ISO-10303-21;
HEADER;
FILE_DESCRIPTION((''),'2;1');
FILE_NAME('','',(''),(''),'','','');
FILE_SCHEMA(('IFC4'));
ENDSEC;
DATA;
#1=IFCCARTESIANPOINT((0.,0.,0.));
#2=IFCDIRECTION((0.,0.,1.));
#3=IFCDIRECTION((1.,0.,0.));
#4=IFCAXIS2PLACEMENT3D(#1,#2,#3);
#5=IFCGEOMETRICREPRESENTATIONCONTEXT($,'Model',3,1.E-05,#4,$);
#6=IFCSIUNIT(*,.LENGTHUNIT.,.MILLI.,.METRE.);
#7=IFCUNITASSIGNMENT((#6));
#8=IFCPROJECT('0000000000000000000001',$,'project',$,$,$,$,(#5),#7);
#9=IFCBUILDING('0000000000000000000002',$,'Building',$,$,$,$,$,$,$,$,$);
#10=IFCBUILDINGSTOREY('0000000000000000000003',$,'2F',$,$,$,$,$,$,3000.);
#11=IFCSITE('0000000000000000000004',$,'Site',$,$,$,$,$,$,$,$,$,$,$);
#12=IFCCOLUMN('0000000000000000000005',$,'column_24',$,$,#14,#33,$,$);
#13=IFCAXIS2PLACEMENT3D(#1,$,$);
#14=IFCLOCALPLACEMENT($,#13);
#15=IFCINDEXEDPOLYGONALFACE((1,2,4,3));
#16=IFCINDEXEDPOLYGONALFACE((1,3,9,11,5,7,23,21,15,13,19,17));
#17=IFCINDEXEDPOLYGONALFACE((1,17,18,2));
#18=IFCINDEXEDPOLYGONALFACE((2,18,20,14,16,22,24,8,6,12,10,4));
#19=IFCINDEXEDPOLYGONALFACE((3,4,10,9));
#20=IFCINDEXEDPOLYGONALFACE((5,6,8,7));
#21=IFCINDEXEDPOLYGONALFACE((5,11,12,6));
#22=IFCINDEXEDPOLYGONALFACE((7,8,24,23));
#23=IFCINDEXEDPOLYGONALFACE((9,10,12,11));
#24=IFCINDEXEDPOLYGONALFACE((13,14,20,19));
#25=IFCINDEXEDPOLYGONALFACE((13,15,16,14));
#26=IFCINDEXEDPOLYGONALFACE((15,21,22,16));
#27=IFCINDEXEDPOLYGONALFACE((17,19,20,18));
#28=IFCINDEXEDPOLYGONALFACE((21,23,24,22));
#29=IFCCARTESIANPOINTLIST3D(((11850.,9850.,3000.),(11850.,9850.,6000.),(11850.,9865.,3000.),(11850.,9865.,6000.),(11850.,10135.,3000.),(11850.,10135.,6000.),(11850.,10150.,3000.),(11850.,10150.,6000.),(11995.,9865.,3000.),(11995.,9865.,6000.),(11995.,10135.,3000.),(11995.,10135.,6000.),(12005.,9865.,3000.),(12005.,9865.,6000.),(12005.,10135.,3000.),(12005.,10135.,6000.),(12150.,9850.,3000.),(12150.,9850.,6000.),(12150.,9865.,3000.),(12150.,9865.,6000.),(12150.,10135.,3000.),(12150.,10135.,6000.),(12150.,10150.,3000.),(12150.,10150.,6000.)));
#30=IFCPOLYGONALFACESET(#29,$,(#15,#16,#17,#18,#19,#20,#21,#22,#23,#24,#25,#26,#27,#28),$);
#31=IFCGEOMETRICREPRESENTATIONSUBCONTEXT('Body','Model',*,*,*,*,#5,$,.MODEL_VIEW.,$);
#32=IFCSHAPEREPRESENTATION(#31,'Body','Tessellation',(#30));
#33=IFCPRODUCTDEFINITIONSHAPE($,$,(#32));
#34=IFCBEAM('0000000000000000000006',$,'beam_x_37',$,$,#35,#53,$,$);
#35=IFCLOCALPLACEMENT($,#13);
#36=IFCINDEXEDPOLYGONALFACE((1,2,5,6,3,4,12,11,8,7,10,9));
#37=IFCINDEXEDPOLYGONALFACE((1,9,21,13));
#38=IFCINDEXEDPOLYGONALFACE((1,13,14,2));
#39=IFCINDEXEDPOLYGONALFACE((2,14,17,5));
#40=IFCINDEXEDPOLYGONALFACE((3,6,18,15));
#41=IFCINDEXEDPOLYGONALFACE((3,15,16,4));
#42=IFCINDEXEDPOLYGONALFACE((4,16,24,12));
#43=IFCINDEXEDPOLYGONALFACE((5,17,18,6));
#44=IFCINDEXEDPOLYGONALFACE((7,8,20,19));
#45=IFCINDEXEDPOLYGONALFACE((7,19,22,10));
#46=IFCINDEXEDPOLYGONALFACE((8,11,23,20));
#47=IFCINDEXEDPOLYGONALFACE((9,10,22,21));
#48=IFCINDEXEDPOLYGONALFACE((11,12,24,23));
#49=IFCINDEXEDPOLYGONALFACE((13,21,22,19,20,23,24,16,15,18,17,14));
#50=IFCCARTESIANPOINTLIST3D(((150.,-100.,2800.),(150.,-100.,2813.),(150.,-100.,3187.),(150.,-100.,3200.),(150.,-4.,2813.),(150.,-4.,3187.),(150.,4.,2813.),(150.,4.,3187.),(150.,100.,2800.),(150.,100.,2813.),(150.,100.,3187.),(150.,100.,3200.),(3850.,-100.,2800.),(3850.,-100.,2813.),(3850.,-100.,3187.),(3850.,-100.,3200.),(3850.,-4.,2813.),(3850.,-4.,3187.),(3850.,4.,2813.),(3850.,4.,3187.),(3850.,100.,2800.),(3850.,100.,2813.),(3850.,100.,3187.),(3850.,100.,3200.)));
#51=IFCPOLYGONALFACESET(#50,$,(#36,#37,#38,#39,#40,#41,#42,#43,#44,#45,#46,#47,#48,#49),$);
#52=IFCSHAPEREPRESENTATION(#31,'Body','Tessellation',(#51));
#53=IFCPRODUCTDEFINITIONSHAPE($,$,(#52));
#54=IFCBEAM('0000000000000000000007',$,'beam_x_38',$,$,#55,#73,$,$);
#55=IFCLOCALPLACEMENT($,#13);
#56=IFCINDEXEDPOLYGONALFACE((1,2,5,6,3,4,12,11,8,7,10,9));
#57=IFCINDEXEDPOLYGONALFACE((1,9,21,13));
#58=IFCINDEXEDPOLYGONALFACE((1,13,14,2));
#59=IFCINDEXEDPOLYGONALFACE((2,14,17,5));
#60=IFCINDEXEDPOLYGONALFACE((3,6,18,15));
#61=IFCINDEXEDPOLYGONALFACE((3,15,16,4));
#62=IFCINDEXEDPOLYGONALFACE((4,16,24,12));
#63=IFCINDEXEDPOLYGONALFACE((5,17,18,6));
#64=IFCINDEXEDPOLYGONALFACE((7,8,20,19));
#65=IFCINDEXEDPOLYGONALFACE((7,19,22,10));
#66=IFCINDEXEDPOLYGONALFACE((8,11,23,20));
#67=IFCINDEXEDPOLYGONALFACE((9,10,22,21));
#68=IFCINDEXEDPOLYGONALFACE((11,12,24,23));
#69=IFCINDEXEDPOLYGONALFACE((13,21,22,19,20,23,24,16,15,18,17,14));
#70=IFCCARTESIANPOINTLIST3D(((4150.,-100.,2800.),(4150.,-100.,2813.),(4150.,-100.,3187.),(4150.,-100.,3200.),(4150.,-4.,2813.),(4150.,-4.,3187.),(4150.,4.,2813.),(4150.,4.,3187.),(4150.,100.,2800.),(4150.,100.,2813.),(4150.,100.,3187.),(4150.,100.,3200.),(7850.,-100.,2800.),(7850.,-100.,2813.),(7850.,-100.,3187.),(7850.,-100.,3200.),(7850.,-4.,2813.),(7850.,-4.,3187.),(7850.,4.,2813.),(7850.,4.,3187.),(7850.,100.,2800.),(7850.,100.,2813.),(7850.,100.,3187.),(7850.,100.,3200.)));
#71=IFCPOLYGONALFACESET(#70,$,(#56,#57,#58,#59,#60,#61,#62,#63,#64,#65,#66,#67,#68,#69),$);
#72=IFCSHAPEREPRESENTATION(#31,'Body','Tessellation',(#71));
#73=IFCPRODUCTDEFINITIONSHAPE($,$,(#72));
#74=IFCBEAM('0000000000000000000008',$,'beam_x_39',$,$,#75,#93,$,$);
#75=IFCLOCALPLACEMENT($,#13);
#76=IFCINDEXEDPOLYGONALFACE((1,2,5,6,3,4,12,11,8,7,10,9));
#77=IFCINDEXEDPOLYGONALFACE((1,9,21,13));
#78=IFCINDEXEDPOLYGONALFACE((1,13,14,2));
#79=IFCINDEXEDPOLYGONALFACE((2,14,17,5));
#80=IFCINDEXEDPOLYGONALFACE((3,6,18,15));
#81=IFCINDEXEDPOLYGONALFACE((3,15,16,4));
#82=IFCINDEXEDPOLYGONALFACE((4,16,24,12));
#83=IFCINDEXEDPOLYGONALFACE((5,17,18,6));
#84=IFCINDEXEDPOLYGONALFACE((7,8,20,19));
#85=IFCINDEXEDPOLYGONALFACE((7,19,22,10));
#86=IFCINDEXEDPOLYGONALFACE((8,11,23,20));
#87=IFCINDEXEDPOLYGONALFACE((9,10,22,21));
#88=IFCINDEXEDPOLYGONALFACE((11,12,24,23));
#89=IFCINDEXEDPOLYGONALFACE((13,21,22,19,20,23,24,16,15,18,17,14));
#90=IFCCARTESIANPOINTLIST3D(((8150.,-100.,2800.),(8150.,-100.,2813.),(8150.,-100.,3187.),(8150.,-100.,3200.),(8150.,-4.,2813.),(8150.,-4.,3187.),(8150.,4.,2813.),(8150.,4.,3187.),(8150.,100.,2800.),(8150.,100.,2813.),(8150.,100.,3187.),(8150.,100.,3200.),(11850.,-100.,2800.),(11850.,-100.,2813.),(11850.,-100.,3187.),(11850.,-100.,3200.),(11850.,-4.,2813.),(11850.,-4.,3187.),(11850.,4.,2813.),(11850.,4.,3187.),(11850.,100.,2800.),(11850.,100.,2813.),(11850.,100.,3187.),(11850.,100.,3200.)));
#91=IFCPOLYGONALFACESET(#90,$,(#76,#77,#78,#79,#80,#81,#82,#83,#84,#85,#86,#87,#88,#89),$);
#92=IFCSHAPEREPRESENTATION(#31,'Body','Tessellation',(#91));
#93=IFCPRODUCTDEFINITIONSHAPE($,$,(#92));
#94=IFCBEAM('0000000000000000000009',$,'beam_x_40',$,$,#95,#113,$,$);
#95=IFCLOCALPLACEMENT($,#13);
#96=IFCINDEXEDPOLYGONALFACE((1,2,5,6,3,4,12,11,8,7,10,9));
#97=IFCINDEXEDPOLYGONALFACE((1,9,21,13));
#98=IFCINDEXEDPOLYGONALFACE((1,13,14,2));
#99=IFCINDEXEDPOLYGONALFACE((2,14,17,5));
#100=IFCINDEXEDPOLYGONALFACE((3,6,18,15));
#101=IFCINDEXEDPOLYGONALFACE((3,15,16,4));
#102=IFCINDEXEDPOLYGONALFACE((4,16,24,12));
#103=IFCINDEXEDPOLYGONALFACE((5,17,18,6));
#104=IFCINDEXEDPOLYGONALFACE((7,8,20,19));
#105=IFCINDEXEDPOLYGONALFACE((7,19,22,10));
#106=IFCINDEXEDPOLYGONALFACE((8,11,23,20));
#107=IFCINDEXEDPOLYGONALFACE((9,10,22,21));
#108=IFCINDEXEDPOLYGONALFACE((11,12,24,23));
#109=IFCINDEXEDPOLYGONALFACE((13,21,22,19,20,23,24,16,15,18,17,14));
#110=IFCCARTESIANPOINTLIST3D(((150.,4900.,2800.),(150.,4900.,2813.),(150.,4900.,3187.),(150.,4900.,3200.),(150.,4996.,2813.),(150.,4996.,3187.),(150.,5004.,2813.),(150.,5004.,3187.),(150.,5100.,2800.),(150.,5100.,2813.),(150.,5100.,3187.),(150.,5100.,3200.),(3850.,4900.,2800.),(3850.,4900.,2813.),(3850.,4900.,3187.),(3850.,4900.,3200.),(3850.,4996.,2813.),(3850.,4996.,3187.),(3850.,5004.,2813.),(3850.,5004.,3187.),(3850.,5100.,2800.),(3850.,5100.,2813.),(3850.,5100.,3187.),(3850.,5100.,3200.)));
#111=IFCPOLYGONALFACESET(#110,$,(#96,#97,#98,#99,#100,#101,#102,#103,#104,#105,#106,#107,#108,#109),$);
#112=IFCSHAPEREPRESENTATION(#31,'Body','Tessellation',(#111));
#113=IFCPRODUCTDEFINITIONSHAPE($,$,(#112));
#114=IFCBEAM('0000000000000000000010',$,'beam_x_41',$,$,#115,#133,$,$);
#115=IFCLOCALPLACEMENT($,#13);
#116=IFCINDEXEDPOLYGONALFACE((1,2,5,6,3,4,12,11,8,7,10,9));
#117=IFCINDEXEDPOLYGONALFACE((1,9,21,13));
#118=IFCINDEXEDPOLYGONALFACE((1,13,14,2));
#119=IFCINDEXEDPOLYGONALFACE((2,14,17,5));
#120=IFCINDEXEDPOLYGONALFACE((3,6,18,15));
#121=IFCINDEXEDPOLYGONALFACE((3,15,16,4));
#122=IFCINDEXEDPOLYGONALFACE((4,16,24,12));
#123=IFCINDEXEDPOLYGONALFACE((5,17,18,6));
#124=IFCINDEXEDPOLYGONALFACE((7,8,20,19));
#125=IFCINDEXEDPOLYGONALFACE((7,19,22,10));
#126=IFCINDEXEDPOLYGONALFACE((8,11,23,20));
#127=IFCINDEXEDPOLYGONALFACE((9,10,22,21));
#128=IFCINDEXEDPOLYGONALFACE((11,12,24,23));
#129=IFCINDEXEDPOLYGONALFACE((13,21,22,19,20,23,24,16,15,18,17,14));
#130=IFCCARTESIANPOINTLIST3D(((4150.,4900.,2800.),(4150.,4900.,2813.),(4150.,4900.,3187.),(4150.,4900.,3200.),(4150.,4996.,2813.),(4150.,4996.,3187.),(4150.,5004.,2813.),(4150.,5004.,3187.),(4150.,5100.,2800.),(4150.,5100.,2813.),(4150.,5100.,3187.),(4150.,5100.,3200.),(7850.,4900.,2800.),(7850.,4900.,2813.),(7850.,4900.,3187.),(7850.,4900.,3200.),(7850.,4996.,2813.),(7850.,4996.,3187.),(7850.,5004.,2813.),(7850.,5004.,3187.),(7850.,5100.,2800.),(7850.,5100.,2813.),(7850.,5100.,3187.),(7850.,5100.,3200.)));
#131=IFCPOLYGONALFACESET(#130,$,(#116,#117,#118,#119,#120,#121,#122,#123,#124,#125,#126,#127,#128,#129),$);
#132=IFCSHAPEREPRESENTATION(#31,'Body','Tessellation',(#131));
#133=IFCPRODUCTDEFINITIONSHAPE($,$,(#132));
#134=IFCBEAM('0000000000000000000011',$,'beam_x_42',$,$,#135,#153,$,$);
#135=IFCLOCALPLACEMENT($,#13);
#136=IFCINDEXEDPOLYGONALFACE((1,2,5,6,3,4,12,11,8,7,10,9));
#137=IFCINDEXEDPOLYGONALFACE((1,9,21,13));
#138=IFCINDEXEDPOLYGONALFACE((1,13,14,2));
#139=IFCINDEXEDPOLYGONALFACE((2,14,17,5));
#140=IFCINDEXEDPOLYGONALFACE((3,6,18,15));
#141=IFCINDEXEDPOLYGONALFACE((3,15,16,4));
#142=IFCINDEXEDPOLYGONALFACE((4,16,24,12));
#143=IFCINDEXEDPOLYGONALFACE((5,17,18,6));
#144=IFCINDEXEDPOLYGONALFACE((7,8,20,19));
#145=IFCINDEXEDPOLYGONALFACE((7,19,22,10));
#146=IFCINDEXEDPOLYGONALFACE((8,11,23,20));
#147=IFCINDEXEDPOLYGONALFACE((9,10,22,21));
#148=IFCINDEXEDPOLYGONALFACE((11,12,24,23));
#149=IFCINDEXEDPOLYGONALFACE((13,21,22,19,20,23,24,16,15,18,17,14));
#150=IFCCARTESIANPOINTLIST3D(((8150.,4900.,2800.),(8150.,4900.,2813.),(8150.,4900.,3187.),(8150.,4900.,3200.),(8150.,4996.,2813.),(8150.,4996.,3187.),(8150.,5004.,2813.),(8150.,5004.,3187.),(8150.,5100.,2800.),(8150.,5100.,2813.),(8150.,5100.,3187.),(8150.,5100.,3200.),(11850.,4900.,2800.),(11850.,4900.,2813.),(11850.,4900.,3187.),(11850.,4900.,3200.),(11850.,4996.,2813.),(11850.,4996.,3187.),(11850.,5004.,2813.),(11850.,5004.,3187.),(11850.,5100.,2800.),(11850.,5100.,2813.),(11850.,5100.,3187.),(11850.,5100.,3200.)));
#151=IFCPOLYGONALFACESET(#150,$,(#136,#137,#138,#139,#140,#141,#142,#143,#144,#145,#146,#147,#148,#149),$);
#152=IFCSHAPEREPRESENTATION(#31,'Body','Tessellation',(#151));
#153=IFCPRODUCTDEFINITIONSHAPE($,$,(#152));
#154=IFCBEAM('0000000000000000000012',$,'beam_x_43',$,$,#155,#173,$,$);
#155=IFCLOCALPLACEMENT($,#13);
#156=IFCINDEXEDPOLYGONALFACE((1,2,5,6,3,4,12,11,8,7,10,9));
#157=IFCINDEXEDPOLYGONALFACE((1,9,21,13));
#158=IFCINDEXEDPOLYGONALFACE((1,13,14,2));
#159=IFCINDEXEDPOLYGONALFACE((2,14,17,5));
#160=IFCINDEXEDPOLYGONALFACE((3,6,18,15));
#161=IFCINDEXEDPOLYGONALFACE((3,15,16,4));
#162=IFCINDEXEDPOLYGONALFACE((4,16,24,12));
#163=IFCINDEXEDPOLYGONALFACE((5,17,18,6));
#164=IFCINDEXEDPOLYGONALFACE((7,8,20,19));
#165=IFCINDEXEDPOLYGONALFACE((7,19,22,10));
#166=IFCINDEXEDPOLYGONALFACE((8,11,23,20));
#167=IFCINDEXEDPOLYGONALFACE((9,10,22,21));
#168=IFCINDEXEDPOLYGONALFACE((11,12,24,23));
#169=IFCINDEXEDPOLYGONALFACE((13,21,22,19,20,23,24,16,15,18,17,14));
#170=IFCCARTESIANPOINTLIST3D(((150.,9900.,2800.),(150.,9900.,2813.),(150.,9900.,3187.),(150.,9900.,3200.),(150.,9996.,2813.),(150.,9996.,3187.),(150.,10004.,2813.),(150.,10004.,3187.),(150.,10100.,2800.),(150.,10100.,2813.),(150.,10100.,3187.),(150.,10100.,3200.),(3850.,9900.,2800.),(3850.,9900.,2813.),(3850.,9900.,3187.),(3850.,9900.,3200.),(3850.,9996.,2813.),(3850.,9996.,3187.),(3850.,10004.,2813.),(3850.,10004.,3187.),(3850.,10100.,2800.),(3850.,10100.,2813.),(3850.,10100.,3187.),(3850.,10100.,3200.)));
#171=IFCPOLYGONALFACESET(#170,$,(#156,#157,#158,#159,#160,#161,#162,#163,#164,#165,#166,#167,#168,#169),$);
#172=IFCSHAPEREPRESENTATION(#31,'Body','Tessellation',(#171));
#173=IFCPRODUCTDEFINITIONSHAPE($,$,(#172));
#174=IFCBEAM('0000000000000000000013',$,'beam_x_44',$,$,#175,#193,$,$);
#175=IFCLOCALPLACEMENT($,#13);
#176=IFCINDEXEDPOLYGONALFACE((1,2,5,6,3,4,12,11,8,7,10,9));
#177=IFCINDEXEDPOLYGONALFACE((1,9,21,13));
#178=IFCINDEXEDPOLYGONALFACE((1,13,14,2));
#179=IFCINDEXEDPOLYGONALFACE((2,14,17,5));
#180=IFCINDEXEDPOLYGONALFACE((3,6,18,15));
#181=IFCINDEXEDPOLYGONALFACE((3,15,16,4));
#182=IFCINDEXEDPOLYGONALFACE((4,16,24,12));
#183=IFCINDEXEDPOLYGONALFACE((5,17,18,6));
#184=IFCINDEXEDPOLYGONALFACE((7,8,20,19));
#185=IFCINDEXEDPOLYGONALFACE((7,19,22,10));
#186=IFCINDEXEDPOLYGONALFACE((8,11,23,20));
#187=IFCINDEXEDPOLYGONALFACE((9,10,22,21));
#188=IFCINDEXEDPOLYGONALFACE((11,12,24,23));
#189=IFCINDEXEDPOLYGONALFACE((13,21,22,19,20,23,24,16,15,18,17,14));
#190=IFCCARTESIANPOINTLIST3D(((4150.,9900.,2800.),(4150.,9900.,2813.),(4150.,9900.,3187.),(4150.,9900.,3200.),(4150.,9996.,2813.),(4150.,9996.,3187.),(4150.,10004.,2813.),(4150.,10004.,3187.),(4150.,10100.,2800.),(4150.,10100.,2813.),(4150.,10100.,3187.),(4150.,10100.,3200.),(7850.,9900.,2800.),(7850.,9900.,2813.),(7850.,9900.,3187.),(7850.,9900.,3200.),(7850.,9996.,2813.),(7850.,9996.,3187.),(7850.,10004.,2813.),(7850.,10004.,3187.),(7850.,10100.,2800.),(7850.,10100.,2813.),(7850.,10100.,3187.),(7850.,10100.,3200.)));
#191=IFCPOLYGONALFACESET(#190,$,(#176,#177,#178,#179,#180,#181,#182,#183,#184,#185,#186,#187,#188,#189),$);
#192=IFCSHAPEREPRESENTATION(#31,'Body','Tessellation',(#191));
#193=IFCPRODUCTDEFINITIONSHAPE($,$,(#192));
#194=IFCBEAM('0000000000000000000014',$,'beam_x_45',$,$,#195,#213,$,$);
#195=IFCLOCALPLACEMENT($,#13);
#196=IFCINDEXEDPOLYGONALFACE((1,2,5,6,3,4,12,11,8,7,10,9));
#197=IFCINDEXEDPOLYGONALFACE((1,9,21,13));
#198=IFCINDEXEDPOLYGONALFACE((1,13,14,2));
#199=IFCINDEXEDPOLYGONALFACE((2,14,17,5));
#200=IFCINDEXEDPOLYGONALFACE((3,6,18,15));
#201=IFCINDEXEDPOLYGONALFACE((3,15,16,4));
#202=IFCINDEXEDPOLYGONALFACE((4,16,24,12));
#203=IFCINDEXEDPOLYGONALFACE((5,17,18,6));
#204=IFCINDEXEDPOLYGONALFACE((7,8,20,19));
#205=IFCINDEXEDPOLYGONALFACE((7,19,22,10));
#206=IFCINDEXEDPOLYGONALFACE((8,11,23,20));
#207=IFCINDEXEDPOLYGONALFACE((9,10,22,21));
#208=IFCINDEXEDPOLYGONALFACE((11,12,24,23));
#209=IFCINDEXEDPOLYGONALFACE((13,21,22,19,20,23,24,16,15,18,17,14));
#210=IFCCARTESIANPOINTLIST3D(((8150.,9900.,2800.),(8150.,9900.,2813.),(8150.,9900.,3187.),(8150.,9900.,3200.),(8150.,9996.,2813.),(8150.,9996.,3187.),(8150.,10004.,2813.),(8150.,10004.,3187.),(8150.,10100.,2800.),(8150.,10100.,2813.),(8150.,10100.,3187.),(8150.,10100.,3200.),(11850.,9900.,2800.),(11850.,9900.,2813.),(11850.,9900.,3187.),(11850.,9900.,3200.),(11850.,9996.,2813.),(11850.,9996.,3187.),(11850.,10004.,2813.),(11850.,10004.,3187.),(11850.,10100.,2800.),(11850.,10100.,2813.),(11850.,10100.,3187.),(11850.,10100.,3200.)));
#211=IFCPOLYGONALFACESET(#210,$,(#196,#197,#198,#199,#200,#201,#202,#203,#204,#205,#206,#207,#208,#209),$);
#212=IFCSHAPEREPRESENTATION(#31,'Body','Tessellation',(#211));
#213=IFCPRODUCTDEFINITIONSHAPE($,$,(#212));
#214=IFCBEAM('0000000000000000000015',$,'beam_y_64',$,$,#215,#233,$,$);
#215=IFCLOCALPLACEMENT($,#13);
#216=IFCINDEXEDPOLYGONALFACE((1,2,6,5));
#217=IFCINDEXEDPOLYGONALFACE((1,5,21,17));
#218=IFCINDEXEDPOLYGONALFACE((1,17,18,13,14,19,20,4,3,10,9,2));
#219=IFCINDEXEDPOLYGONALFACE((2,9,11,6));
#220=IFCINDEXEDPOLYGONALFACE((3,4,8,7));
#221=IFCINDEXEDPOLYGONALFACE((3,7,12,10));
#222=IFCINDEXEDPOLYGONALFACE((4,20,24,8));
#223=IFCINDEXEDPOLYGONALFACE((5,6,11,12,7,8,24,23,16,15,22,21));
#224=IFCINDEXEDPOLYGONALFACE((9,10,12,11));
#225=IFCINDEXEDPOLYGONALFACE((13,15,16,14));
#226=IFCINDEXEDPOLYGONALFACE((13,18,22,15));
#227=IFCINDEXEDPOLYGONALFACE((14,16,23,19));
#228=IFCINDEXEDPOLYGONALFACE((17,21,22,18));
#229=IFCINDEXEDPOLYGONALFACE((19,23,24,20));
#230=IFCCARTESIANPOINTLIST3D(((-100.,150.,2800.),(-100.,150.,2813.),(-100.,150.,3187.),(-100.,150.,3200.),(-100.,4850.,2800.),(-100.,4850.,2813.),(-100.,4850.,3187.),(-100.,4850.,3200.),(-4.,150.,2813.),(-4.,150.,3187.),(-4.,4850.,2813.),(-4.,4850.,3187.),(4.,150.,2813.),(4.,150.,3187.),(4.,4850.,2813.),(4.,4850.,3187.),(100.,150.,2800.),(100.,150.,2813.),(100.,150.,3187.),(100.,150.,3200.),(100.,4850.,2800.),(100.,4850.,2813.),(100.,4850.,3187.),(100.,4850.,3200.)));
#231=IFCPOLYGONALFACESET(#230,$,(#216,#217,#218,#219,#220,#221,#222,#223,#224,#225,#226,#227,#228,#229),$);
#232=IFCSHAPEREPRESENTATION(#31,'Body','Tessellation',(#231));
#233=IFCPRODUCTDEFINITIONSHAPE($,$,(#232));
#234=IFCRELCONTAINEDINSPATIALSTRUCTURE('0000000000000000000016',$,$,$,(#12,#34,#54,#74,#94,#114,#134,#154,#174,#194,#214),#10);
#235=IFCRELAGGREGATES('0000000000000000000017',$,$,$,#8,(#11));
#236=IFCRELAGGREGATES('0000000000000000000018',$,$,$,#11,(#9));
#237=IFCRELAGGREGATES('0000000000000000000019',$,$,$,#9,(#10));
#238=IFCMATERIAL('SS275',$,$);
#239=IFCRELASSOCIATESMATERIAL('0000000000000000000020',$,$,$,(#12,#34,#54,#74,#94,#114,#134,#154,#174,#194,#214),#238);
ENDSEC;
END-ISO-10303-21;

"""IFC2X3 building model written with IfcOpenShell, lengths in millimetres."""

from ifc_helpers import new_model, si_unit, frame, origin, origin_with_axes, origin_2d_with_axis, place, context, subcontext, project, spatial, i_section, extrude, material, element, save


model = new_model("IFC2X3")

# Units and contexts
model_context = context("Model", 3, precision=1e-05, world=origin_with_axes())
body_context = subcontext(model_context, "Body", "Model", "MODEL_VIEW")
ifc_project = project(units=[si_unit("LENGTHUNIT", "METRE", prefix="MILLI")], contexts=[model_context])

# Site, building, storey
site = spatial("IfcSite", under=ifc_project, Name="Site")
building = spatial("IfcBuilding", under=site, Name="Building")
storey = spatial("IfcBuildingStorey", under=building, Name="2F", Elevation=3000.0)

# Column
ifc_material = material(Name="SS275")
for number, where, z_axis, x_axis, name in (
    (1, (12000.0, 10000.0, 3000.0), (0.0, 0.0, 1.0), (1.0, 0.0, 0.0), "column_24"),
):
    element("IfcColumn", number, at=place(None, frame(where, z_axis=z_axis, x_axis=x_axis)), inside=storey, material=ifc_material, Name=name, context=body_context, shape_type="SweptSolid", body=[
        extrude(i_section(OverallWidth=300.0, OverallDepth=300.0, WebThickness=10.0, FlangeThickness=15.0, at=origin_2d_with_axis()), origin(), (0.0, 0.0, 1.0), 3000.0),
    ])

# Beams
for number, where, z_axis, x_axis, name in (
    (2, (150.0, 0.0, 3000.0), (1.0, 0.0, 0.0), (0.0, 1.0, 0.0), "beam_x_37"),
    (3, (4150.0, 0.0, 3000.0), (1.0, 0.0, 0.0), (0.0, 1.0, 0.0), "beam_x_38"),
    (4, (8150.0, 0.0, 3000.0), (1.0, 0.0, 0.0), (0.0, 1.0, 0.0), "beam_x_39"),
    (5, (150.0, 5000.0, 3000.0), (1.0, 0.0, 0.0), (0.0, 1.0, 0.0), "beam_x_40"),
    (6, (4150.0, 5000.0, 3000.0), (1.0, 0.0, 0.0), (0.0, 1.0, 0.0), "beam_x_41"),
    (7, (8150.0, 5000.0, 3000.0), (1.0, 0.0, 0.0), (0.0, 1.0, 0.0), "beam_x_42"),
    (8, (150.0, 10000.0, 3000.0), (1.0, 0.0, 0.0), (0.0, 1.0, 0.0), "beam_x_43"),
    (9, (4150.0, 10000.0, 3000.0), (1.0, 0.0, 0.0), (0.0, 1.0, 0.0), "beam_x_44"),
    (10, (8150.0, 10000.0, 3000.0), (1.0, 0.0, 0.0), (0.0, 1.0, 0.0), "beam_x_45"),
):
    element("IfcBeam", number, at=place(None, frame(where, z_axis=z_axis, x_axis=x_axis)), inside=storey, material=ifc_material, Name=name, context=body_context, shape_type="SweptSolid", body=[
        extrude(i_section(OverallWidth=200.0, OverallDepth=400.0, WebThickness=8.0, FlangeThickness=13.0, at=origin_2d_with_axis()), origin(), (0.0, 0.0, 1.0), 3700.0),
    ])
for number, where, z_axis, x_axis, name in (
    (11, (0.0, 150.0, 3000.0), (0.0, 1.0, 0.0), (-1.0, 0.0, 0.0), "beam_y_64"),
):
    element("IfcBeam", number, at=place(None, frame(where, z_axis=z_axis, x_axis=x_axis)), inside=storey, material=ifc_material, Name=name, context=body_context, shape_type="SweptSolid", body=[
        extrude(i_section(OverallWidth=200.0, OverallDepth=400.0, WebThickness=8.0, FlangeThickness=13.0, at=origin_2d_with_axis()), origin(), (0.0, 0.0, 1.0), 4700.0),
    ])

save(model, "model.ifc")
